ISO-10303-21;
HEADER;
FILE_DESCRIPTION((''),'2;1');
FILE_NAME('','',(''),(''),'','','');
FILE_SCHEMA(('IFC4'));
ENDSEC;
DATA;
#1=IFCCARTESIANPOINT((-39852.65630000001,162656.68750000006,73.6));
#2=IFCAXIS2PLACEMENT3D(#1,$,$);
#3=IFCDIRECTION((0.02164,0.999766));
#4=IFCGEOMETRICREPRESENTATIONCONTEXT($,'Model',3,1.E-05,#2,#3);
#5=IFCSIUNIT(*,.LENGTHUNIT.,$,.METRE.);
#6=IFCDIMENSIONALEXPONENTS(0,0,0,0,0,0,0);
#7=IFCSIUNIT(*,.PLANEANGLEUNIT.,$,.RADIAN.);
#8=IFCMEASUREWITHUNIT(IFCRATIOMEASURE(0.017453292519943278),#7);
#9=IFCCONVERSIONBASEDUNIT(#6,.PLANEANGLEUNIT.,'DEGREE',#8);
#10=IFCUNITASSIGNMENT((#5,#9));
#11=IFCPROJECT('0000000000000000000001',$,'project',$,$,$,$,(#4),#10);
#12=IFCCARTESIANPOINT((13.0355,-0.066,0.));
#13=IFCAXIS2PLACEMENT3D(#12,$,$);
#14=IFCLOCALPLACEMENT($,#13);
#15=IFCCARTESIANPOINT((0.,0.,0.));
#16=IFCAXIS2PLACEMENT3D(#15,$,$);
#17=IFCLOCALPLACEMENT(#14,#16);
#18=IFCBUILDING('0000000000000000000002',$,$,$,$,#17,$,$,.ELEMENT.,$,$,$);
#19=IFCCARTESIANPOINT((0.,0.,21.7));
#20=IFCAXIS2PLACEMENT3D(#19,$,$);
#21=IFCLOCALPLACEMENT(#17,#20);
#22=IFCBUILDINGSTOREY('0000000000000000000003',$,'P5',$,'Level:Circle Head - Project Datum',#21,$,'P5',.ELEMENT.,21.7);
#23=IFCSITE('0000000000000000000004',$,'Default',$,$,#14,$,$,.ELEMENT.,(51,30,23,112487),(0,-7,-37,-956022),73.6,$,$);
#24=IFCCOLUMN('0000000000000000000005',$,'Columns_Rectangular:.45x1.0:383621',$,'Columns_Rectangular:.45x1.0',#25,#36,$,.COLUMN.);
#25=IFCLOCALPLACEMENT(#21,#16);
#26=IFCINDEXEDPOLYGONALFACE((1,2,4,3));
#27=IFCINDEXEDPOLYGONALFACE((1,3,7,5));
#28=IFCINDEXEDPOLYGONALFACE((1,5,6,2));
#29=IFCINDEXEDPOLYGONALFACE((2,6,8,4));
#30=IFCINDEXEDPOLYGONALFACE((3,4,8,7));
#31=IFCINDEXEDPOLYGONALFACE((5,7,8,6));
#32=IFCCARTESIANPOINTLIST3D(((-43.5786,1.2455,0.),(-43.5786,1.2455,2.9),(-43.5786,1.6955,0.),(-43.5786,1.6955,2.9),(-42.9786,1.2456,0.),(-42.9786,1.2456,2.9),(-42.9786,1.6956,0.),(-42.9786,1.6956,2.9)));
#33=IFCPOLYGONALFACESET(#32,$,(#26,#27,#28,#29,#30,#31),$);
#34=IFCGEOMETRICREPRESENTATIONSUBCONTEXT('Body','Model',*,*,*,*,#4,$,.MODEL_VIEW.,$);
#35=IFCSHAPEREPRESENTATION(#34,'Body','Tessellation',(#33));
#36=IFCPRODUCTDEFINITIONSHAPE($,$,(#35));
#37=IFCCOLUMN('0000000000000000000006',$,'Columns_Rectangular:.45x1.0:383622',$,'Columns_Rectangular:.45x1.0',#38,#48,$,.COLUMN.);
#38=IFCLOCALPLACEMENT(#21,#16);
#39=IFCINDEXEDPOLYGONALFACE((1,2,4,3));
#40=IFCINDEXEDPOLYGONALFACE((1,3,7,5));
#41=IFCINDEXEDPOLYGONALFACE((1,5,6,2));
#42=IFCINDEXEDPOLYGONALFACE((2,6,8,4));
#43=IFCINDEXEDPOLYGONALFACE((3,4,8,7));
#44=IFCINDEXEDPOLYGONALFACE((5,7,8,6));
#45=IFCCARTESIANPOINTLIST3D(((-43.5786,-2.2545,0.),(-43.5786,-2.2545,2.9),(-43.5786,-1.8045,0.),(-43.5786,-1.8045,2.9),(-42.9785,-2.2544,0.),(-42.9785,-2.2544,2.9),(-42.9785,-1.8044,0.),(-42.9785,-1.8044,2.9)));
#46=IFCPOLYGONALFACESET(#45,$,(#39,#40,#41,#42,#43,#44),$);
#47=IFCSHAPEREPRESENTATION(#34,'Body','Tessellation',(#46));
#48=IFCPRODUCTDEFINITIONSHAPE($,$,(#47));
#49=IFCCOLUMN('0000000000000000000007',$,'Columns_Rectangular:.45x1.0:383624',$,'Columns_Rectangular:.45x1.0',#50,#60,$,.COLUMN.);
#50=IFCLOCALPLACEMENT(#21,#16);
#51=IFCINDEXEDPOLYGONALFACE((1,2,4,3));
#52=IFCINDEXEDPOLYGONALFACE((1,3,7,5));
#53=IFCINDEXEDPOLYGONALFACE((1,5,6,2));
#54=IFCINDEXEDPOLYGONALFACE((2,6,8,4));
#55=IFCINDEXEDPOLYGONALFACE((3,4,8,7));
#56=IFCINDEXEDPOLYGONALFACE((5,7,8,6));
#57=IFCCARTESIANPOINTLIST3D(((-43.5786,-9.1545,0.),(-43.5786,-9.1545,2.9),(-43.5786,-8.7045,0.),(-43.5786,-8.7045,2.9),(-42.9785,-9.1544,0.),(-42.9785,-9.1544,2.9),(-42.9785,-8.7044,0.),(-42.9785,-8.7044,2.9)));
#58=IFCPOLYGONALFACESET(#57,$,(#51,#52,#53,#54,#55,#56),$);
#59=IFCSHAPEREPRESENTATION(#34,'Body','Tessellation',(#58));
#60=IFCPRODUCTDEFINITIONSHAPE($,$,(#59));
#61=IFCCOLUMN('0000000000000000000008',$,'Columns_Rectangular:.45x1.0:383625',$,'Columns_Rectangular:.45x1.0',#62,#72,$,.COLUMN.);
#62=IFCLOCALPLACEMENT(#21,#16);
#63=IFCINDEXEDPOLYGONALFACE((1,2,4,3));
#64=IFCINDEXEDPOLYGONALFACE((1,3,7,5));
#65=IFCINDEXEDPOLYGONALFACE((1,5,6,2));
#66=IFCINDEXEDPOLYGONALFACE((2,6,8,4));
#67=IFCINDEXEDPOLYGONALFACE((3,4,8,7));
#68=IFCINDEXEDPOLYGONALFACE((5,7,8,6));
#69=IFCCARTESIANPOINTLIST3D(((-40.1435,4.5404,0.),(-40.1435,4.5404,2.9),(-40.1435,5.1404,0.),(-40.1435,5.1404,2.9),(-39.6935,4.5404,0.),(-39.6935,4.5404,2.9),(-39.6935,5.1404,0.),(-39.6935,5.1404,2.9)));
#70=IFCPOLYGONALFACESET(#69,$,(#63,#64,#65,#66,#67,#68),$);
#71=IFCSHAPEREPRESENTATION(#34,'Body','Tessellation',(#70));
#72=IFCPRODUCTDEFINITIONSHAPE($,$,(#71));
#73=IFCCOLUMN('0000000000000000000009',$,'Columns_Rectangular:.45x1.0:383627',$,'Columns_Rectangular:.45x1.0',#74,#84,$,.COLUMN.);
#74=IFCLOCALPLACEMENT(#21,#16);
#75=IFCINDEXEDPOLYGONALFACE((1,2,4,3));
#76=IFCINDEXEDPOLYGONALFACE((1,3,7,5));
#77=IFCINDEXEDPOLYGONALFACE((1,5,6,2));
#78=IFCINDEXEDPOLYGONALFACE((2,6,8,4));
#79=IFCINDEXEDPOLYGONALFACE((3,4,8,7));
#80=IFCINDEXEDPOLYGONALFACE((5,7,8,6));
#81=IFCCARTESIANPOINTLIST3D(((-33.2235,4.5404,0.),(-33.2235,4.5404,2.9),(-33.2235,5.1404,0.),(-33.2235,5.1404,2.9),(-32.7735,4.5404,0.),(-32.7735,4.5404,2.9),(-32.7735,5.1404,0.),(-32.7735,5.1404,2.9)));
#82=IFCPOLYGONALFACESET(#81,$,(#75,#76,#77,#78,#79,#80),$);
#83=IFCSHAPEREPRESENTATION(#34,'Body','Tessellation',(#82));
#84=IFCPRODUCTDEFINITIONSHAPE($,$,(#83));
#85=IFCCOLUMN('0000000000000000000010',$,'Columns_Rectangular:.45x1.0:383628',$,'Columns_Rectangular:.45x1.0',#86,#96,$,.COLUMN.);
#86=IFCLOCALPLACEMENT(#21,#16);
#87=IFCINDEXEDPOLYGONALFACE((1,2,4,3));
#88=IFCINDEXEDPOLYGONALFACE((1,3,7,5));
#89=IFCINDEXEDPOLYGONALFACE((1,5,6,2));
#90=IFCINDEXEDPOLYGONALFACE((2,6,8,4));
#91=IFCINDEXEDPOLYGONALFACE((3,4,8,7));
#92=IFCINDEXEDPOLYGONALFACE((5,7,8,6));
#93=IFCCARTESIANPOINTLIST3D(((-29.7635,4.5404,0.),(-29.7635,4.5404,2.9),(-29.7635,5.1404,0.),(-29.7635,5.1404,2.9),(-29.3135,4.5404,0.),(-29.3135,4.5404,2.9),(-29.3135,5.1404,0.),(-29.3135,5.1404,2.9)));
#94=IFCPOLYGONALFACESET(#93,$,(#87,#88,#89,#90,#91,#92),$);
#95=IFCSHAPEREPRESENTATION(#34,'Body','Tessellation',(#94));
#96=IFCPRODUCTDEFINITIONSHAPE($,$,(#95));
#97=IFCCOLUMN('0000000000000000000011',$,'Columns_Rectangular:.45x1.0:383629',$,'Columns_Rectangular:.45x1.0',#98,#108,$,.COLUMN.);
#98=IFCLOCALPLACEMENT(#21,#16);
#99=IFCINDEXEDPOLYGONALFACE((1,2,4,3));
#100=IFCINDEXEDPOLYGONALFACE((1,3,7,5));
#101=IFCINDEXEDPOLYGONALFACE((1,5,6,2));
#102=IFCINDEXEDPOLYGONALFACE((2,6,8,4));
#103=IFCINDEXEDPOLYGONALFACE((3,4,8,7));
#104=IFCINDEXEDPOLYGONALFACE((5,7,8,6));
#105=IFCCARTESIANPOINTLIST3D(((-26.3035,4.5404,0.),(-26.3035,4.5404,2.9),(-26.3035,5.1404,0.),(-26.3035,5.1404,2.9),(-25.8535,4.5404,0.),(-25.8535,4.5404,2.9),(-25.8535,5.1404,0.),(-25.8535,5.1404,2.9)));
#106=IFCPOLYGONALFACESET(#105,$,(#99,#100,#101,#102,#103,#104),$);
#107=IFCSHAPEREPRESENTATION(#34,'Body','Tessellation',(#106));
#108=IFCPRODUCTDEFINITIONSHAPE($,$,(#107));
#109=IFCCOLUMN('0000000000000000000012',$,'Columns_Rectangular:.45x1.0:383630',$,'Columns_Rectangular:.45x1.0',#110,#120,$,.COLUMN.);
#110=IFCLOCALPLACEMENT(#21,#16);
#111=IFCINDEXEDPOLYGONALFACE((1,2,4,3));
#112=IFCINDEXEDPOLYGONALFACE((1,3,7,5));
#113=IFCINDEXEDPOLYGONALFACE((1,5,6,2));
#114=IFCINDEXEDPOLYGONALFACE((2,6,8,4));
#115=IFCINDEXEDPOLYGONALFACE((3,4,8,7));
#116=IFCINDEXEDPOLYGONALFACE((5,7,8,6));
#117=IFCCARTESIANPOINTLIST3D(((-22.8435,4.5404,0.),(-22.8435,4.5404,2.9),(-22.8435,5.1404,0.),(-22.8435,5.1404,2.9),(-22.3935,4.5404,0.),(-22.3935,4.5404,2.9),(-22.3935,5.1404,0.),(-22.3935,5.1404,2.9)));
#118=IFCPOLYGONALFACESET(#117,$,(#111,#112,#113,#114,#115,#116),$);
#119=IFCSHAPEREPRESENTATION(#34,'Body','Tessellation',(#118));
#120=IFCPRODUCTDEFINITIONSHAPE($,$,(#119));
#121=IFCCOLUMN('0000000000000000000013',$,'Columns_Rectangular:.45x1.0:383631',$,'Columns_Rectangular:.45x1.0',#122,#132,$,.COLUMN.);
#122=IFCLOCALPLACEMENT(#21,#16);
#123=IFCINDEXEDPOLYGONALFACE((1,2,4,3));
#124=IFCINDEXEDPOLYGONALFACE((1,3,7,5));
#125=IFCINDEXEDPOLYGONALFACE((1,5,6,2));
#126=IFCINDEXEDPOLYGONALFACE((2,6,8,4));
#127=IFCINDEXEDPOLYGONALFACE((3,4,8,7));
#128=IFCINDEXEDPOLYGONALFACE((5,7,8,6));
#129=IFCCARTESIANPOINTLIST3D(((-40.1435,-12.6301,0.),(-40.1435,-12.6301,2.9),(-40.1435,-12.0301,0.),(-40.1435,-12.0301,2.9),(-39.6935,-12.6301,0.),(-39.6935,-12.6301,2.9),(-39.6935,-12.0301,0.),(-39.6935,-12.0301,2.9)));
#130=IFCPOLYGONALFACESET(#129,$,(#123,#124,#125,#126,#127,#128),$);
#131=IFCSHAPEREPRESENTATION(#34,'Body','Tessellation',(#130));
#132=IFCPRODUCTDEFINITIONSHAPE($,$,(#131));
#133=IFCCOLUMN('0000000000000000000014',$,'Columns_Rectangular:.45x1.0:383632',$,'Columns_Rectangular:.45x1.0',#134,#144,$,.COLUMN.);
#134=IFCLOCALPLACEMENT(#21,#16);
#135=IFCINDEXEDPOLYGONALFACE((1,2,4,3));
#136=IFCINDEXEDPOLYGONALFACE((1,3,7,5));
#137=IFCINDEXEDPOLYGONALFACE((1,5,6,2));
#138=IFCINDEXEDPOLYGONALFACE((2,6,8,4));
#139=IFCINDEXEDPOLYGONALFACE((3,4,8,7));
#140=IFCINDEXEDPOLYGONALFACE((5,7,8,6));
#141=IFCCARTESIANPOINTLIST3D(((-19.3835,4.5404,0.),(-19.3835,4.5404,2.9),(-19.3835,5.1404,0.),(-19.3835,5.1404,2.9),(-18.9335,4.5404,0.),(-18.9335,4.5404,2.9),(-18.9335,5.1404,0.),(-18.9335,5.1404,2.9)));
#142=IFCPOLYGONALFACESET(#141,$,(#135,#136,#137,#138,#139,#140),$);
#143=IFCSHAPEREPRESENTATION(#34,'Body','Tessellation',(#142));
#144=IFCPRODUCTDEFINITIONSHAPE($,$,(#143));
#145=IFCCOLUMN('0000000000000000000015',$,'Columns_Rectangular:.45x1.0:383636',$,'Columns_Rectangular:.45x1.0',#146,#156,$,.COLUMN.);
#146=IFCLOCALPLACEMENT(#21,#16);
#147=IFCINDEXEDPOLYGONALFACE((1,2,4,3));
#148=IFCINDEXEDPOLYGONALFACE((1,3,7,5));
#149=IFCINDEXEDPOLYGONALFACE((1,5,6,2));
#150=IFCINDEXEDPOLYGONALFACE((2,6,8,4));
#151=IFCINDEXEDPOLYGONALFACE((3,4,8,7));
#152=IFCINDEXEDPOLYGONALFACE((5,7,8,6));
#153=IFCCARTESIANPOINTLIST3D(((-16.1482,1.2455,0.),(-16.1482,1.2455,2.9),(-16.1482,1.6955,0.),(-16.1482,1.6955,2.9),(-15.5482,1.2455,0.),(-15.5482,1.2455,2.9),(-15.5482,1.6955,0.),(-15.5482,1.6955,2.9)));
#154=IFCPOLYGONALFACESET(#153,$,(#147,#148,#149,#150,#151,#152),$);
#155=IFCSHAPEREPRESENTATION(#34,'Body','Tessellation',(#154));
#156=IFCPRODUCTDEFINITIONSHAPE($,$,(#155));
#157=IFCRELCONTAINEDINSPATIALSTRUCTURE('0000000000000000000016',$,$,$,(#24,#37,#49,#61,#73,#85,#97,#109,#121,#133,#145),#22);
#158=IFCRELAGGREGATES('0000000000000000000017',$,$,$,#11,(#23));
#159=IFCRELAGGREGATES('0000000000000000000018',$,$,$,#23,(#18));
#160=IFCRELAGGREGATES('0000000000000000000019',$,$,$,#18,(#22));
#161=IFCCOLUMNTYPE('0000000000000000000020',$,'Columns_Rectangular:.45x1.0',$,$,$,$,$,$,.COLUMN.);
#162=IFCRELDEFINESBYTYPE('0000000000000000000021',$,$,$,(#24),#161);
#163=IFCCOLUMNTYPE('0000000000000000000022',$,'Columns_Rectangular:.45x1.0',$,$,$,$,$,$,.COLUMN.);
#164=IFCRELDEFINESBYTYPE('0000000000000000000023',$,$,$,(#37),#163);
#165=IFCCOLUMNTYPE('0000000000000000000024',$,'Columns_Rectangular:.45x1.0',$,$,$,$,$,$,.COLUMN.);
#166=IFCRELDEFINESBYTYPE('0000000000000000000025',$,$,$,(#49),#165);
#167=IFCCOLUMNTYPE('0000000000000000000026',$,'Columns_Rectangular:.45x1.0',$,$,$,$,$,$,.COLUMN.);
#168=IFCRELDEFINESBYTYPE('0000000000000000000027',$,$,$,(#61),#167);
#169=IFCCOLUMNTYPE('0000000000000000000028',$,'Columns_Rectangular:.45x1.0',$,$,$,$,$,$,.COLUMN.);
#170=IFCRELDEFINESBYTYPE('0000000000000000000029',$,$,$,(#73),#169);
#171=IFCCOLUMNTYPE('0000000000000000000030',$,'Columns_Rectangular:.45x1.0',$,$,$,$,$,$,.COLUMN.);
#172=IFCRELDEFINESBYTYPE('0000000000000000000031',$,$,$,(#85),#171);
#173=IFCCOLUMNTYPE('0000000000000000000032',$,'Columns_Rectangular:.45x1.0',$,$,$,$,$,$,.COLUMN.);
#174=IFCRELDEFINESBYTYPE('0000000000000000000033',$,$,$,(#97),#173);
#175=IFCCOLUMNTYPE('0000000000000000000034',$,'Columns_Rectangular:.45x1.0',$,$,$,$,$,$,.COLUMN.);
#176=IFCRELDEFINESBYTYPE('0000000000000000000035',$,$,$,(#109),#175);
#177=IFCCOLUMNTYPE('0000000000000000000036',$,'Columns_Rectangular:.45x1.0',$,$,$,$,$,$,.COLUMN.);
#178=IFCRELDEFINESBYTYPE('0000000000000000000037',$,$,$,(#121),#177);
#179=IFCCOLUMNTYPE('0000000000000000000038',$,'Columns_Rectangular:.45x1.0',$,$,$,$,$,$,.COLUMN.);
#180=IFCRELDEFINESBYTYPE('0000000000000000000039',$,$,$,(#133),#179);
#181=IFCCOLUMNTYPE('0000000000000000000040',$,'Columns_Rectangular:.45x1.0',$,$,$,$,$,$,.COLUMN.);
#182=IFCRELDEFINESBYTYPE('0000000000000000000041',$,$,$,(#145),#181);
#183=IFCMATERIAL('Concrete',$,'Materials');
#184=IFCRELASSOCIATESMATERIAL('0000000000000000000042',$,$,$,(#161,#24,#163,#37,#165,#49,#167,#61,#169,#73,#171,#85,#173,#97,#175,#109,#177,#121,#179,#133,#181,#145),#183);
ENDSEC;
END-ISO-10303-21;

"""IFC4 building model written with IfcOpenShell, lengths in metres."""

from ifc_helpers import new_model, entity, si_unit, converted_unit, direction, frame, origin, place, context, subcontext, project, spatial, indexed_curve, outline, extrude, source, transform, mapped, material, type_object, type_shapes, element, save


model = new_model("IFC4")

# Units and contexts
model_context = context("Model", 3, precision=1e-05, world=frame((-39852.65630000001, 162656.68750000006, 73.6)), true_north=direction((0.02164, 0.999766)))
body_context = subcontext(model_context, "Body", "Model", "MODEL_VIEW")
ifc_project = project(units=[si_unit("LENGTHUNIT", "METRE"), converted_unit("PLANEANGLEUNIT", "DEGREE", entity("IfcRatioMeasure", 0.017453292519943278), si_unit("PLANEANGLEUNIT", "RADIAN"), dimensions=[0, 0, 0, 0, 0, 0, 0])], contexts=[model_context])

# Site, building, storey
site_placement = place(None, frame((13.0355, -0.066, 0.0)))
site = spatial("IfcSite", under=ifc_project, at=site_placement, Name="Default", CompositionType="ELEMENT", RefLatitude=(51, 30, 23, 112487), RefLongitude=(0, -7, -37, -956022), RefElevation=73.6)
building_placement = place(site_placement, origin())
building = spatial("IfcBuilding", under=site, at=building_placement, CompositionType="ELEMENT")
storey_placement = place(building_placement, frame((0.0, 0.0, 21.7)))
storey = spatial("IfcBuildingStorey", under=building, at=storey_placement, Name="P5", ObjectType="Level:Circle Head - Project Datum", LongName="P5", CompositionType="ELEMENT", Elevation=21.7)

# Columns
ifc_material = material(Name="Concrete", Category="Materials")
column_type_1 = type_object("IfcColumnType", Name="Columns_Rectangular:.45x1.0", PredefinedType="COLUMN", material=ifc_material)
shared_shape_1 = source(origin(), body_context, "Body", "SweptSolid", [
    extrude(outline(indexed_curve([(-0.3, -0.225), (0.3, -0.225), (0.3, 0.225), (-0.3, 0.225), (-0.3, -0.225)], self_intersect=False)), frame((-43.2786, 1.4706, 21.7), z_axis=(0.0, 0.0, 1.0), x_axis=(-1.0, -0.000005, 0.0)), (0.0, 0.0, 1.0), 2.9),
])
type_shapes(column_type_1, [shared_shape_1])
column_1_placement = place(storey_placement, frame((0.0, 0.0, -21.7)))
element("IfcColumn", 1, at=column_1_placement, inside=storey, type_object=column_type_1, material=ifc_material, Name="Columns_Rectangular:.45x1.0:383621", ObjectType="Columns_Rectangular:.45x1.0", PredefinedType="COLUMN", context=body_context, shape_type="MappedRepresentation", body=[
    mapped(shared_shape_1, transform((0.0, 0.0, 0.0), scale=1.0)),
])
column_type_2 = type_object("IfcColumnType", Name="Columns_Rectangular:.45x1.0", PredefinedType="COLUMN", material=ifc_material)
shared_shape_2 = source(origin(), body_context, "Body", "SweptSolid", [
    extrude(outline(indexed_curve([(-0.3, -0.225), (0.3, -0.225), (0.3, 0.225), (-0.3, 0.225), (-0.3, -0.225)], self_intersect=False)), frame((-43.2785, -2.0294, 21.7), z_axis=(0.0, 0.0, 1.0), x_axis=(-1.0, -0.000005, 0.0)), (0.0, 0.0, 1.0), 2.9),
])
type_shapes(column_type_2, [shared_shape_2])
column_2_placement = place(storey_placement, frame((0.0, 0.0, -21.7)))
element("IfcColumn", 2, at=column_2_placement, inside=storey, type_object=column_type_2, material=ifc_material, Name="Columns_Rectangular:.45x1.0:383622", ObjectType="Columns_Rectangular:.45x1.0", PredefinedType="COLUMN", context=body_context, shape_type="MappedRepresentation", body=[
    mapped(shared_shape_2, transform((0.0, 0.0, 0.0), scale=1.0)),
])
column_type_3 = type_object("IfcColumnType", Name="Columns_Rectangular:.45x1.0", PredefinedType="COLUMN", material=ifc_material)
shared_shape_3 = source(origin(), body_context, "Body", "SweptSolid", [
    extrude(outline(indexed_curve([(-0.3, -0.225), (0.3, -0.225), (0.3, 0.225), (-0.3, 0.225), (-0.3, -0.225)], self_intersect=False)), frame((-43.2785, -8.9294, 21.7), z_axis=(0.0, 0.0, 1.0), x_axis=(-1.0, -0.000005, 0.0)), (0.0, 0.0, 1.0), 2.9),
])
type_shapes(column_type_3, [shared_shape_3])
column_3_placement = place(storey_placement, frame((0.0, 0.0, -21.7)))
element("IfcColumn", 3, at=column_3_placement, inside=storey, type_object=column_type_3, material=ifc_material, Name="Columns_Rectangular:.45x1.0:383624", ObjectType="Columns_Rectangular:.45x1.0", PredefinedType="COLUMN", context=body_context, shape_type="MappedRepresentation", body=[
    mapped(shared_shape_3, transform((0.0, 0.0, 0.0), scale=1.0)),
])
column_type_4 = type_object("IfcColumnType", Name="Columns_Rectangular:.45x1.0", PredefinedType="COLUMN", material=ifc_material)
shared_shape_4 = source(origin(), body_context, "Body", "SweptSolid", [
    extrude(outline(indexed_curve([(-0.3, -0.225), (0.3, -0.225), (0.3, 0.225), (-0.3, 0.225), (-0.3, -0.225)], self_intersect=False)), frame((-39.9185, 4.8404, 21.7), z_axis=(0.0, 0.0, 1.0), x_axis=(0.0, -1.0, 0.0)), (0.0, 0.0, 1.0), 2.9),
])
type_shapes(column_type_4, [shared_shape_4])
column_4_placement = place(storey_placement, frame((0.0, 0.0, -21.7)))
element("IfcColumn", 4, at=column_4_placement, inside=storey, type_object=column_type_4, material=ifc_material, Name="Columns_Rectangular:.45x1.0:383625", ObjectType="Columns_Rectangular:.45x1.0", PredefinedType="COLUMN", context=body_context, shape_type="MappedRepresentation", body=[
    mapped(shared_shape_4, transform((0.0, 0.0, 0.0), scale=1.0)),
])
column_type_5 = type_object("IfcColumnType", Name="Columns_Rectangular:.45x1.0", PredefinedType="COLUMN", material=ifc_material)
shared_shape_5 = source(origin(), body_context, "Body", "SweptSolid", [
    extrude(outline(indexed_curve([(-0.3, -0.225), (0.3, -0.225), (0.3, 0.225), (-0.3, 0.225), (-0.3, -0.225)], self_intersect=False)), frame((-32.9985, 4.8404, 21.7), z_axis=(0.0, 0.0, 1.0), x_axis=(0.0, -1.0, 0.0)), (0.0, 0.0, 1.0), 2.9),
])
type_shapes(column_type_5, [shared_shape_5])
column_5_placement = place(storey_placement, frame((0.0, 0.0, -21.7)))
element("IfcColumn", 5, at=column_5_placement, inside=storey, type_object=column_type_5, material=ifc_material, Name="Columns_Rectangular:.45x1.0:383627", ObjectType="Columns_Rectangular:.45x1.0", PredefinedType="COLUMN", context=body_context, shape_type="MappedRepresentation", body=[
    mapped(shared_shape_5, transform((0.0, 0.0, 0.0), scale=1.0)),
])
column_type_6 = type_object("IfcColumnType", Name="Columns_Rectangular:.45x1.0", PredefinedType="COLUMN", material=ifc_material)
shared_shape_6 = source(origin(), body_context, "Body", "SweptSolid", [
    extrude(outline(indexed_curve([(-0.3, -0.225), (0.3, -0.225), (0.3, 0.225), (-0.3, 0.225), (-0.3, -0.225)], self_intersect=False)), frame((-29.5385, 4.8404, 21.7), z_axis=(0.0, 0.0, 1.0), x_axis=(0.0, -1.0, 0.0)), (0.0, 0.0, 1.0), 2.9),
])
type_shapes(column_type_6, [shared_shape_6])
column_6_placement = place(storey_placement, frame((0.0, 0.0, -21.7)))
element("IfcColumn", 6, at=column_6_placement, inside=storey, type_object=column_type_6, material=ifc_material, Name="Columns_Rectangular:.45x1.0:383628", ObjectType="Columns_Rectangular:.45x1.0", PredefinedType="COLUMN", context=body_context, shape_type="MappedRepresentation", body=[
    mapped(shared_shape_6, transform((0.0, 0.0, 0.0), scale=1.0)),
])
column_type_7 = type_object("IfcColumnType", Name="Columns_Rectangular:.45x1.0", PredefinedType="COLUMN", material=ifc_material)
shared_shape_7 = source(origin(), body_context, "Body", "SweptSolid", [
    extrude(outline(indexed_curve([(-0.3, -0.225), (0.3, -0.225), (0.3, 0.225), (-0.3, 0.225), (-0.3, -0.225)], self_intersect=False)), frame((-26.0785, 4.8404, 21.7), z_axis=(0.0, 0.0, 1.0), x_axis=(0.0, -1.0, 0.0)), (0.0, 0.0, 1.0), 2.9),
])
type_shapes(column_type_7, [shared_shape_7])
column_7_placement = place(storey_placement, frame((0.0, 0.0, -21.7)))
element("IfcColumn", 7, at=column_7_placement, inside=storey, type_object=column_type_7, material=ifc_material, Name="Columns_Rectangular:.45x1.0:383629", ObjectType="Columns_Rectangular:.45x1.0", PredefinedType="COLUMN", context=body_context, shape_type="MappedRepresentation", body=[
    mapped(shared_shape_7, transform((0.0, 0.0, 0.0), scale=1.0)),
])
column_type_8 = type_object("IfcColumnType", Name="Columns_Rectangular:.45x1.0", PredefinedType="COLUMN", material=ifc_material)
shared_shape_8 = source(origin(), body_context, "Body", "SweptSolid", [
    extrude(outline(indexed_curve([(-0.3, -0.225), (0.3, -0.225), (0.3, 0.225), (-0.3, 0.225), (-0.3, -0.225)], self_intersect=False)), frame((-22.6185, 4.8404, 21.7), z_axis=(0.0, 0.0, 1.0), x_axis=(0.0, -1.0, 0.0)), (0.0, 0.0, 1.0), 2.9),
])
type_shapes(column_type_8, [shared_shape_8])
column_8_placement = place(storey_placement, frame((0.0, 0.0, -21.7)))
element("IfcColumn", 8, at=column_8_placement, inside=storey, type_object=column_type_8, material=ifc_material, Name="Columns_Rectangular:.45x1.0:383630", ObjectType="Columns_Rectangular:.45x1.0", PredefinedType="COLUMN", context=body_context, shape_type="MappedRepresentation", body=[
    mapped(shared_shape_8, transform((0.0, 0.0, 0.0), scale=1.0)),
])
column_type_9 = type_object("IfcColumnType", Name="Columns_Rectangular:.45x1.0", PredefinedType="COLUMN", material=ifc_material)
shared_shape_9 = source(origin(), body_context, "Body", "SweptSolid", [
    extrude(outline(indexed_curve([(-0.3, -0.225), (0.3, -0.225), (0.3, 0.225), (-0.3, 0.225), (-0.3, -0.225)], self_intersect=False)), frame((-39.9185, -12.3301, 21.7), z_axis=(0.0, 0.0, 1.0), x_axis=(0.000011, 1.0, 0.0)), (0.0, 0.0, 1.0), 2.9),
])
type_shapes(column_type_9, [shared_shape_9])
column_9_placement = place(storey_placement, frame((0.0, 0.0, -21.7)))
element("IfcColumn", 9, at=column_9_placement, inside=storey, type_object=column_type_9, material=ifc_material, Name="Columns_Rectangular:.45x1.0:383631", ObjectType="Columns_Rectangular:.45x1.0", PredefinedType="COLUMN", context=body_context, shape_type="MappedRepresentation", body=[
    mapped(shared_shape_9, transform((0.0, 0.0, 0.0), scale=1.0)),
])
column_type_10 = type_object("IfcColumnType", Name="Columns_Rectangular:.45x1.0", PredefinedType="COLUMN", material=ifc_material)
shared_shape_10 = source(origin(), body_context, "Body", "SweptSolid", [
    extrude(outline(indexed_curve([(-0.3, -0.225), (0.3, -0.225), (0.3, 0.225), (-0.3, 0.225), (-0.3, -0.225)], self_intersect=False)), frame((-19.1585, 4.8404, 21.7), z_axis=(0.0, 0.0, 1.0), x_axis=(0.0, -1.0, 0.0)), (0.0, 0.0, 1.0), 2.9),
])
type_shapes(column_type_10, [shared_shape_10])
column_10_placement = place(storey_placement, frame((0.0, 0.0, -21.7)))
element("IfcColumn", 10, at=column_10_placement, inside=storey, type_object=column_type_10, material=ifc_material, Name="Columns_Rectangular:.45x1.0:383632", ObjectType="Columns_Rectangular:.45x1.0", PredefinedType="COLUMN", context=body_context, shape_type="MappedRepresentation", body=[
    mapped(shared_shape_10, transform((0.0, 0.0, 0.0), scale=1.0)),
])
column_type_11 = type_object("IfcColumnType", Name="Columns_Rectangular:.45x1.0", PredefinedType="COLUMN", material=ifc_material)
shared_shape_11 = source(origin(), body_context, "Body", "SweptSolid", [
    extrude(outline(indexed_curve([(-0.225, -0.3), (0.225, -0.3), (0.225, 0.3), (-0.225, 0.3), (-0.225, -0.3)], self_intersect=False)), frame((-15.8482, 1.4705, 21.7), z_axis=(0.0, 0.0, 1.0), x_axis=(0.0, -1.0, 0.0)), (0.0, 0.0, 1.0), 2.9),
])
type_shapes(column_type_11, [shared_shape_11])
column_11_placement = place(storey_placement, frame((0.0, 0.0, -21.7)))
element("IfcColumn", 11, at=column_11_placement, inside=storey, type_object=column_type_11, material=ifc_material, Name="Columns_Rectangular:.45x1.0:383636", ObjectType="Columns_Rectangular:.45x1.0", PredefinedType="COLUMN", context=body_context, shape_type="MappedRepresentation", body=[
    mapped(shared_shape_11, transform((0.0, 0.0, 0.0), scale=1.0)),
])

save(model, "model.ifc")
